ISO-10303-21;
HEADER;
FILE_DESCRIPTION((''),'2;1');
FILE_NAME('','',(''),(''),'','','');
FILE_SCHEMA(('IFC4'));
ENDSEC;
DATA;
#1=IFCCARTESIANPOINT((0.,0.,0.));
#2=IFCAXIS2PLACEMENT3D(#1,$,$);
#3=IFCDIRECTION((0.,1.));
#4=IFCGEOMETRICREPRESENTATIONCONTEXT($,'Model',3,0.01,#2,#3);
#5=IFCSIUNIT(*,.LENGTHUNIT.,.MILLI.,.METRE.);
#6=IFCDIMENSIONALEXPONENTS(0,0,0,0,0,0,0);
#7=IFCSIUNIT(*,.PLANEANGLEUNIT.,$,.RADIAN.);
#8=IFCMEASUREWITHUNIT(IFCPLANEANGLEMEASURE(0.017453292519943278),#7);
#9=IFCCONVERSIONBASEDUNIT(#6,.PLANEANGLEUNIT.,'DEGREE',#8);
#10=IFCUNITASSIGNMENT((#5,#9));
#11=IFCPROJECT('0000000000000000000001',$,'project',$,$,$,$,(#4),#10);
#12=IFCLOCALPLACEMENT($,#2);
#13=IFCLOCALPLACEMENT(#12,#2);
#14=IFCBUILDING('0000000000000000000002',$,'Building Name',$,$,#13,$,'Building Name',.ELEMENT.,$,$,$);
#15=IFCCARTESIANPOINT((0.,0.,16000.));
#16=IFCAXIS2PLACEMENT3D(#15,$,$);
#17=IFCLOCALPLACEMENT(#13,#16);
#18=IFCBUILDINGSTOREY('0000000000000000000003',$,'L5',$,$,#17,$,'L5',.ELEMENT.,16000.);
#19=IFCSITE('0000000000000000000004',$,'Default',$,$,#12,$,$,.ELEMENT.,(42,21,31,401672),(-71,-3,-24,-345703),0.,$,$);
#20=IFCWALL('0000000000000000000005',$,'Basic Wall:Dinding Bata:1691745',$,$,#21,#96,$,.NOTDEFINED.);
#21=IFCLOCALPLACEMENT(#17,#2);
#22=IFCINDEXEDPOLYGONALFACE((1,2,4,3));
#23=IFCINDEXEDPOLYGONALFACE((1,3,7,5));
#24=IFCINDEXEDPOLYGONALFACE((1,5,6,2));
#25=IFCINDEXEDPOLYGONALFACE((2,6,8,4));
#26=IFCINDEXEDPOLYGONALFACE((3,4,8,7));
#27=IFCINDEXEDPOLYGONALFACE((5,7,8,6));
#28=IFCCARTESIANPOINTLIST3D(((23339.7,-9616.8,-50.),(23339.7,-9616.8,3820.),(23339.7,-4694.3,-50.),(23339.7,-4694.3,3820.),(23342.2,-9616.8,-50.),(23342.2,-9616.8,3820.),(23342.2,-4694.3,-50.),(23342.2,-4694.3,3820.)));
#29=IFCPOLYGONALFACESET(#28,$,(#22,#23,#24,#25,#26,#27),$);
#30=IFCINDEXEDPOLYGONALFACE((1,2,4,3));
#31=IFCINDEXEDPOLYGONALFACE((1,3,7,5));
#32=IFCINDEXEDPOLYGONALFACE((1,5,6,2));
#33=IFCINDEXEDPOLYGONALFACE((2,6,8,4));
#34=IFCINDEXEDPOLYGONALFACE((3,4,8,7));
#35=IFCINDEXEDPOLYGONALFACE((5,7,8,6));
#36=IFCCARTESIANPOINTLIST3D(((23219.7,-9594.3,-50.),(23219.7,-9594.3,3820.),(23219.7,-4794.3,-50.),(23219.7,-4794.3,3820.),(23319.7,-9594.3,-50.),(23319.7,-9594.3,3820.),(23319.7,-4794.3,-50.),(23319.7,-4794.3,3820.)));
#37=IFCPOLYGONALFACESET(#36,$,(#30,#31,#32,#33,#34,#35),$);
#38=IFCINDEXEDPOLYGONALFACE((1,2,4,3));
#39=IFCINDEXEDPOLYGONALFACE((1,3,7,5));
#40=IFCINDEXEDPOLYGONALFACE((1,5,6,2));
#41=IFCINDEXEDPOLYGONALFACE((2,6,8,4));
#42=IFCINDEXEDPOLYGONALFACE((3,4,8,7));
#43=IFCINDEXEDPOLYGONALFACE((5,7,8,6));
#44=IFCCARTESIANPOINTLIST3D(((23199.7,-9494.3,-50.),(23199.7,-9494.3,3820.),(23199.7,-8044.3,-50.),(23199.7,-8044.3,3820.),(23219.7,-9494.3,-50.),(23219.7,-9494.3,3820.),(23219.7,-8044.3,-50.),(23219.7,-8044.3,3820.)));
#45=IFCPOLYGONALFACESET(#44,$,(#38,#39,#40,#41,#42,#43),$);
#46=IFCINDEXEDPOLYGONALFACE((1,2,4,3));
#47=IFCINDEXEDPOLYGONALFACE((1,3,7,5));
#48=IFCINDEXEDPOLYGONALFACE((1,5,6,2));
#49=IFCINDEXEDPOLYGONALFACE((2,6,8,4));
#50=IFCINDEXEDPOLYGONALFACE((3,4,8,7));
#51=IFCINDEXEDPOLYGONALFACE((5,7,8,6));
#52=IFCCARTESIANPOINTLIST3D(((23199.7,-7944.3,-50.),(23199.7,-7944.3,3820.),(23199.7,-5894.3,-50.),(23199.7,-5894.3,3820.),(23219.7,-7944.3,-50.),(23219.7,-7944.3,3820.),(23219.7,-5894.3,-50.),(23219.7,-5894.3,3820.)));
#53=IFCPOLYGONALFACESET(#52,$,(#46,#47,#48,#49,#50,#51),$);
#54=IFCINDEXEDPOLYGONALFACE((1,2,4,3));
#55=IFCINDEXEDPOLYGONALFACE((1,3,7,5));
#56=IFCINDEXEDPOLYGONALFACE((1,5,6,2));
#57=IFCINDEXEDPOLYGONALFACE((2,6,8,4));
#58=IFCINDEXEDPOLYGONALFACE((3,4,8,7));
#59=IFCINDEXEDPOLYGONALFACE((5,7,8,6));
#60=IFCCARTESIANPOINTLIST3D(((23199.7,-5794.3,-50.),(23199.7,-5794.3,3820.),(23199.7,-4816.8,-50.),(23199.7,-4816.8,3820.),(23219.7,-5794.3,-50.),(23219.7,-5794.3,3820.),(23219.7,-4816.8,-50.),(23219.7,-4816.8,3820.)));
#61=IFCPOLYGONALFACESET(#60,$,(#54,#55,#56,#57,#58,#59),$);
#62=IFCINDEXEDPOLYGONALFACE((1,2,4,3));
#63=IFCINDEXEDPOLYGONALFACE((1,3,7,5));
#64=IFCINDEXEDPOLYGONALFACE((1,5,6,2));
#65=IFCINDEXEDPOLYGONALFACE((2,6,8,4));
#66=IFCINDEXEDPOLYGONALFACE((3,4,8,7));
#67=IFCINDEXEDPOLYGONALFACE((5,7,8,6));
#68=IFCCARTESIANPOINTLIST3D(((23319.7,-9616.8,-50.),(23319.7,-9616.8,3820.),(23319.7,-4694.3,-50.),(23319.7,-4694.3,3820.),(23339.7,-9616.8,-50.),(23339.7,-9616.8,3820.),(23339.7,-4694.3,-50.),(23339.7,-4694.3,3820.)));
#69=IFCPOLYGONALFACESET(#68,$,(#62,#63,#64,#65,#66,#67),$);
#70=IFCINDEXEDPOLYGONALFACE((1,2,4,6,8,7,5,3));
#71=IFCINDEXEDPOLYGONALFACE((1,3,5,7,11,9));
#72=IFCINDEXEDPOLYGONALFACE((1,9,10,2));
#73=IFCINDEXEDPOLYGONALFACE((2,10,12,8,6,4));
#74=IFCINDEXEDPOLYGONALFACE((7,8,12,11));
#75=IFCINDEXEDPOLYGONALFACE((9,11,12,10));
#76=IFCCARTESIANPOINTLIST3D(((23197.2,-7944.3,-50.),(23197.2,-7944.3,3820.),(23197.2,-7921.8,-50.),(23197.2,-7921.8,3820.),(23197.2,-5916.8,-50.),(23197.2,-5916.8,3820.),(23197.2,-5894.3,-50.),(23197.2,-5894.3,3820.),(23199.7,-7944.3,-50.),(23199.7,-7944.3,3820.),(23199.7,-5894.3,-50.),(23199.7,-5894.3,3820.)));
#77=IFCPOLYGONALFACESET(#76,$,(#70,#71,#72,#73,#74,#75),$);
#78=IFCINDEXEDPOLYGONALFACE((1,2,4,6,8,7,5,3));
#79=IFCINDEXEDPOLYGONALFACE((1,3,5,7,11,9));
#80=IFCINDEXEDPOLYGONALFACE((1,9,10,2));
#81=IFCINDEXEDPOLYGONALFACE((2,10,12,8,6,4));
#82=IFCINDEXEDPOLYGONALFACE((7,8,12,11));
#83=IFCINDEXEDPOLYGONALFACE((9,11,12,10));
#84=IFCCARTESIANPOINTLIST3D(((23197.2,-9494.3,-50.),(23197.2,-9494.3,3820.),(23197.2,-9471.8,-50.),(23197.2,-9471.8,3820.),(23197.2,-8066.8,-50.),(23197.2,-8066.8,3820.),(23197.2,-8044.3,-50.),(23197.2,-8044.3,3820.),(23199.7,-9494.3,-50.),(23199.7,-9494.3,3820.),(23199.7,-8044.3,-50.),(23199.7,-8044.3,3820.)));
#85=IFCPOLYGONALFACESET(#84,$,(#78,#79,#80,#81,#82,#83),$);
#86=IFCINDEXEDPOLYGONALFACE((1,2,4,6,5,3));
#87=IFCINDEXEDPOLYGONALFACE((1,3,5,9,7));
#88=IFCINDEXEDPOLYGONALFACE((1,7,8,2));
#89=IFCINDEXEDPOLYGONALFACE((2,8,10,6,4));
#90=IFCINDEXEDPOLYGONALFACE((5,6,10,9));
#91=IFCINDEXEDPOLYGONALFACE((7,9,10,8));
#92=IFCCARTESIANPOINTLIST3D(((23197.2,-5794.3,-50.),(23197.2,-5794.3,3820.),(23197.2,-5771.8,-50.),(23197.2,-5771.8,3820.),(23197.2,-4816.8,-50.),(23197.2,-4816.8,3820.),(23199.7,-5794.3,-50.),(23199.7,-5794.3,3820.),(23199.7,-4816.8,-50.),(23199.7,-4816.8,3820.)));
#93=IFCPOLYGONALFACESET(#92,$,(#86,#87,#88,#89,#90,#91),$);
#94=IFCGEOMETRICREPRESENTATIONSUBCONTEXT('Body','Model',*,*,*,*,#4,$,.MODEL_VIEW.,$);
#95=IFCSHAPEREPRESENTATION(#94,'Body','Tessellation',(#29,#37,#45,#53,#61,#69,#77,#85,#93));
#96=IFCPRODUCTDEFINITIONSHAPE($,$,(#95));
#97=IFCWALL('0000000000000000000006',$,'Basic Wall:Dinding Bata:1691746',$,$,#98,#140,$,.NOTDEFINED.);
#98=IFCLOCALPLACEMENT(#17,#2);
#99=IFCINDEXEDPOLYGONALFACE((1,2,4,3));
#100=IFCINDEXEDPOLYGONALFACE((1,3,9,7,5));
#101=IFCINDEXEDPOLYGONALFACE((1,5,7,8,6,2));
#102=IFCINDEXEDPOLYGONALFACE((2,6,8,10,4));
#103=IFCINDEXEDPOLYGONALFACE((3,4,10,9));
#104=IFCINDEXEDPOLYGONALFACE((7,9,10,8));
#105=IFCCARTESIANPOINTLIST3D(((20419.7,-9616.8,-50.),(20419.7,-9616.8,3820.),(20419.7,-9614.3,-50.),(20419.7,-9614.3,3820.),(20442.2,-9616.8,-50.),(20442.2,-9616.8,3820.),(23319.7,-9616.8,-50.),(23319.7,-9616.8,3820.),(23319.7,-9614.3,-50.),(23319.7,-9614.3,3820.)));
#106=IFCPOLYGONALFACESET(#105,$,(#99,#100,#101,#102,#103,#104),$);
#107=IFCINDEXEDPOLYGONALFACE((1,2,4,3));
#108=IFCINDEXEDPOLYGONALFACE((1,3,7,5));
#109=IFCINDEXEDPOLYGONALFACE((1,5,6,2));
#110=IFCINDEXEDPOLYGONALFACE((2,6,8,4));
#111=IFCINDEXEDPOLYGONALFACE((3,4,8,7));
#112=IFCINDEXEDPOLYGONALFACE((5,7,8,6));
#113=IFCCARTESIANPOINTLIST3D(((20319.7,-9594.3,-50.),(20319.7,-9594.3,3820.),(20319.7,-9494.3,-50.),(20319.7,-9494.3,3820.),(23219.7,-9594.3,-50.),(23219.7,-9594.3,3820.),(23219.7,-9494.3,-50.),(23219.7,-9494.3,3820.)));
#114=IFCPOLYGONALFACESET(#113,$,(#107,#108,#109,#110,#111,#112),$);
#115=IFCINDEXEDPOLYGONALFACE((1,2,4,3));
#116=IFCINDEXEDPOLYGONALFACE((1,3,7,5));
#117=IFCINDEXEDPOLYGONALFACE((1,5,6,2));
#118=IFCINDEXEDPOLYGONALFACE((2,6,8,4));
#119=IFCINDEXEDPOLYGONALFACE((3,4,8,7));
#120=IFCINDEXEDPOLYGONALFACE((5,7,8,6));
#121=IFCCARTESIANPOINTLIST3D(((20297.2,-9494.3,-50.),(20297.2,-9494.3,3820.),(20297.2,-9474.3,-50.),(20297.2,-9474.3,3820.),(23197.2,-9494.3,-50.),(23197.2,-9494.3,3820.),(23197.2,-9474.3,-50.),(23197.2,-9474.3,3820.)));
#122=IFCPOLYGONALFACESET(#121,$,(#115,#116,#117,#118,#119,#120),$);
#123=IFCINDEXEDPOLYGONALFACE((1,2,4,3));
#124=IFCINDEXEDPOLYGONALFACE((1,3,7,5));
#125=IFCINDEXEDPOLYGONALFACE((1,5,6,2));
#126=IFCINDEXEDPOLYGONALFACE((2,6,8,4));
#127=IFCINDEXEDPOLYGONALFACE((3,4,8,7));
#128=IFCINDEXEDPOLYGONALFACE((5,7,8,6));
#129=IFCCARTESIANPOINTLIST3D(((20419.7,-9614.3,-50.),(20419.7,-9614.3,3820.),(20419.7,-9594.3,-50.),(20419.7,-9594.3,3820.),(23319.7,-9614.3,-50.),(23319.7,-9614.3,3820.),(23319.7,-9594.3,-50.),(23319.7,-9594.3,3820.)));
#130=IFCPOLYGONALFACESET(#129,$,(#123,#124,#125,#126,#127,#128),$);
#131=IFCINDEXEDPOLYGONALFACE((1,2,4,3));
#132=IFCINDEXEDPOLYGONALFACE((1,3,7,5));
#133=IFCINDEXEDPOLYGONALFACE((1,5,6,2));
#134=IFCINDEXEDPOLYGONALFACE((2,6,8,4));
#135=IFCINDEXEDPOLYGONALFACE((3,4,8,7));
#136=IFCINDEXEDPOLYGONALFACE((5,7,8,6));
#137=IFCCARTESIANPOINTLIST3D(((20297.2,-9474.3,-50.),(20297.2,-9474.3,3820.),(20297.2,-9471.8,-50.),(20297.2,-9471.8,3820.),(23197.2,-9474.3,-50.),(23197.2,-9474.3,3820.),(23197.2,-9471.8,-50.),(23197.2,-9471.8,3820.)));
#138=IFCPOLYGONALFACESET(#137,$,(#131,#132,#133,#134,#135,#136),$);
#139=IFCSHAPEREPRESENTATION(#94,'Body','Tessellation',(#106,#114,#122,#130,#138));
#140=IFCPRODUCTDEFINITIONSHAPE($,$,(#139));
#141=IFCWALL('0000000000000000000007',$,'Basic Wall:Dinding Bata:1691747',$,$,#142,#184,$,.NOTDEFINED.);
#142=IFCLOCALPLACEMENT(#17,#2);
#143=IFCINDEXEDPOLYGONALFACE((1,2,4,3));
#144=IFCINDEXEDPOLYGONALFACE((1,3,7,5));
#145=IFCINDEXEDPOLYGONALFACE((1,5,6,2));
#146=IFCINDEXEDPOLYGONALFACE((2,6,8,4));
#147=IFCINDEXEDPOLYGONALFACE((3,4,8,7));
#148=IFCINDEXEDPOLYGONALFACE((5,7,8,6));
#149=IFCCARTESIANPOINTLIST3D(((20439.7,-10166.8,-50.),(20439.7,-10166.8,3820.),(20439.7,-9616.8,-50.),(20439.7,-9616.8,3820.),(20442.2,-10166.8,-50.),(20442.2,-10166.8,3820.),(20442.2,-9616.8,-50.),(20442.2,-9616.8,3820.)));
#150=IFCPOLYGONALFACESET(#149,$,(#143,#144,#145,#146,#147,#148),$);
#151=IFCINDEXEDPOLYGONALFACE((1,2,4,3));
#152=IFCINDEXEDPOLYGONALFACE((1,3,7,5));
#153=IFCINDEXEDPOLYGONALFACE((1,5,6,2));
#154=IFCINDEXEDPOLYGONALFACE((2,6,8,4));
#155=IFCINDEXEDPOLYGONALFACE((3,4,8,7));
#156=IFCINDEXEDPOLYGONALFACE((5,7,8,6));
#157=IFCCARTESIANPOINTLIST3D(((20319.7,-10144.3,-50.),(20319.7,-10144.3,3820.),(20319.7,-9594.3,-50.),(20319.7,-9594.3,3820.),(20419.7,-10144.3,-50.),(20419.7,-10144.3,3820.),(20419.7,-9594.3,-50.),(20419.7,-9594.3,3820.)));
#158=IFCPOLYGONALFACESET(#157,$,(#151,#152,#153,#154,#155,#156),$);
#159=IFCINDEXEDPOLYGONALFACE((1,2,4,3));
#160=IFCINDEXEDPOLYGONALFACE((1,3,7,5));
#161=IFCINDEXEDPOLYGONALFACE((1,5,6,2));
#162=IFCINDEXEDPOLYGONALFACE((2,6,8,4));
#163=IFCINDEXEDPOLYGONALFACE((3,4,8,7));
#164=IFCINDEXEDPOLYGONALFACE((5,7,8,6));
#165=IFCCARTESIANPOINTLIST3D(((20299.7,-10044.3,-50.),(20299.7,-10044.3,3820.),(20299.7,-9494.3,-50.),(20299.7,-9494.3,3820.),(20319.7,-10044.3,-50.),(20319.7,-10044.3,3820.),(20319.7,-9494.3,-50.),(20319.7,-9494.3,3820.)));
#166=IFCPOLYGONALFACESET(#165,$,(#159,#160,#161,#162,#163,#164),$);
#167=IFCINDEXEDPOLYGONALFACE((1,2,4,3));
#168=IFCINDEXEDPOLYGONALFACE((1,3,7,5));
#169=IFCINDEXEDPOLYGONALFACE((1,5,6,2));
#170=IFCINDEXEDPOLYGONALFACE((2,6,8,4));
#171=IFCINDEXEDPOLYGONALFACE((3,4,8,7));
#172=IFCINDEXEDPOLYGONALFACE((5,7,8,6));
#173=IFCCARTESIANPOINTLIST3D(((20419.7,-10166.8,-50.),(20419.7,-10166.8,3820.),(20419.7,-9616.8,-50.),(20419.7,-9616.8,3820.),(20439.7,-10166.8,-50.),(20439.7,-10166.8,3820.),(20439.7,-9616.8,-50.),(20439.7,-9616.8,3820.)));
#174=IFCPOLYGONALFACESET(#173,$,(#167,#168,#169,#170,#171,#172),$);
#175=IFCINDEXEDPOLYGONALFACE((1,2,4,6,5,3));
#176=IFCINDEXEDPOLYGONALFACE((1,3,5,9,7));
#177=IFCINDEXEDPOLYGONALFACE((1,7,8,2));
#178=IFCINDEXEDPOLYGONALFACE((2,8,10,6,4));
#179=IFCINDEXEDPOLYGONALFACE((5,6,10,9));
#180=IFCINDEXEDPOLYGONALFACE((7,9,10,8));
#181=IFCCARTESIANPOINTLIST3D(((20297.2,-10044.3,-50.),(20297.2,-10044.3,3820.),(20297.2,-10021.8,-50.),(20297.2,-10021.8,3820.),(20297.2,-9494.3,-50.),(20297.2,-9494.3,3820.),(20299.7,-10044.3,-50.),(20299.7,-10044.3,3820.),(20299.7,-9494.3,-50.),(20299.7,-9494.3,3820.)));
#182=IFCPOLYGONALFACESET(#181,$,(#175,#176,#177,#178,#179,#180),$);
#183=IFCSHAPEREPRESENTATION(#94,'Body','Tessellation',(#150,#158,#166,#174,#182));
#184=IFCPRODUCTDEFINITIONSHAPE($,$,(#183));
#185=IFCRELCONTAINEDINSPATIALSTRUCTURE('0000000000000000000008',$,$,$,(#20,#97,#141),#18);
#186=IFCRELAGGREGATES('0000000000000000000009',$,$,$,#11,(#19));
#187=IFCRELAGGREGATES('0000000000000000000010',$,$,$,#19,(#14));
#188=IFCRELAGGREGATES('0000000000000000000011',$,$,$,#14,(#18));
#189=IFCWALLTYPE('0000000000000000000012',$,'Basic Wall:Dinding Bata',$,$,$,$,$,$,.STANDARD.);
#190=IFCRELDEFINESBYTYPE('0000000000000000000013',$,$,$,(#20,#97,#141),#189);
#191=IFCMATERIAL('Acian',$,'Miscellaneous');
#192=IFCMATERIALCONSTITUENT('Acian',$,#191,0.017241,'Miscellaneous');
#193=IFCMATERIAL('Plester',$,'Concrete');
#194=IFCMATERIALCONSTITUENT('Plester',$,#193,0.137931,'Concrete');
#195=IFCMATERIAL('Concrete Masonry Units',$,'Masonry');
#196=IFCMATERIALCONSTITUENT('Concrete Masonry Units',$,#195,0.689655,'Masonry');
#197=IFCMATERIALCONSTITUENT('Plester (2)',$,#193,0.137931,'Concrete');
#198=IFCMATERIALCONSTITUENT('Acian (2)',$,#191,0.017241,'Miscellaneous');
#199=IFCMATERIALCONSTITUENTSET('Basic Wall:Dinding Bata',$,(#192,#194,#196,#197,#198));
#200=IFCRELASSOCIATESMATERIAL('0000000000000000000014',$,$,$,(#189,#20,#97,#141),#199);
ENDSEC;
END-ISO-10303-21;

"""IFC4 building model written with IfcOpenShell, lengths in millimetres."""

from ifc_helpers import new_model, entity, si_unit, converted_unit, direction, frame, origin, place, context, subcontext, project, spatial, indexed_curve, outline, extrude, material, constituent, constituent_set, type_object, element, save


model = new_model("IFC4")

# Units and contexts
model_context = context("Model", 3, precision=0.01, world=origin(), true_north=direction((0.0, 1.0)))
body_context = subcontext(model_context, "Body", "Model", "MODEL_VIEW")
ifc_project = project(units=[si_unit("LENGTHUNIT", "METRE", prefix="MILLI"), converted_unit("PLANEANGLEUNIT", "DEGREE", entity("IfcPlaneAngleMeasure", 0.017453292519943278), si_unit("PLANEANGLEUNIT", "RADIAN"), dimensions=[0, 0, 0, 0, 0, 0, 0])], contexts=[model_context])

# Site, building, storey
site_placement = place(None, origin())
site = spatial("IfcSite", under=ifc_project, at=site_placement, Name="Default", CompositionType="ELEMENT", RefLatitude=(42, 21, 31, 401672), RefLongitude=(-71, -3, -24, -345703), RefElevation=0.0)
building_placement = place(site_placement, origin())
building = spatial("IfcBuilding", under=site, at=building_placement, Name="Building Name", LongName="Building Name", CompositionType="ELEMENT")
storey_placement = place(building_placement, frame((0.0, 0.0, 16000.0)))
storey = spatial("IfcBuildingStorey", under=building, at=storey_placement, Name="L5", LongName="L5", CompositionType="ELEMENT", Elevation=16000.0)

# Walls
ifc_material_1 = material(Name="Acian", Category="Miscellaneous")
ifc_constituent_1 = constituent(ifc_material_1, Name="Acian", Category="Miscellaneous", fraction=0.017241)
ifc_material_2 = material(Name="Plester", Category="Concrete")
ifc_constituent_2 = constituent(ifc_material_2, Name="Plester", Category="Concrete", fraction=0.137931)
ifc_material_3 = material(Name="Concrete Masonry Units", Category="Masonry")
ifc_constituent_3 = constituent(ifc_material_3, Name="Concrete Masonry Units", Category="Masonry", fraction=0.689655)
ifc_constituent_4 = constituent(ifc_material_2, Name="Plester (2)", Category="Concrete", fraction=0.137931)
ifc_constituent_5 = constituent(ifc_material_1, Name="Acian (2)", Category="Miscellaneous", fraction=0.017241)
ifc_constituent_set = constituent_set(constituents=[ifc_constituent_1, ifc_constituent_2, ifc_constituent_3, ifc_constituent_4, ifc_constituent_5], Name="Basic Wall:Dinding Bata")
wall_type = type_object("IfcWallType", Name="Basic Wall:Dinding Bata", PredefinedType="STANDARD", material=ifc_constituent_set)
wall_1_placement = place(storey_placement, frame((23269.7, -4816.8, -50.0), z_axis=(0.0, 0.0, 1.0), x_axis=(0.0, -1.0, 0.0)))
element("IfcWall", 1, at=wall_1_placement, inside=storey, type_object=wall_type, material=ifc_constituent_set, Name="Basic Wall:Dinding Bata:1691745", PredefinedType="NOTDEFINED", context=body_context, shape_type="SweptSolid", body=[
    extrude(outline(indexed_curve([(-1.3, -2461.3), (1.2, -2461.3), (1.3, 2461.3), (-1.2, 2461.3), (-1.3, -2461.3)], self_intersect=False)), frame((2338.8, 71.3, 0.0), z_axis=(0.0, 0.0, 1.0), x_axis=(0.0, -1.0, 0.0)), (0.0, 0.0, 1.0), 3870.0),
    extrude(outline(indexed_curve([(-2400.0, -50.0), (2400.0, -50.0), (2400.0, 50.0), (-2400.0, 50.0), (-2400.0, -50.0)], self_intersect=False)), frame((2377.5, 0.0, 0.0)), (0.0, 0.0, 1.0), 3870.0),
    extrude(outline(indexed_curve([(-725.0, -10.0), (725.0, -10.0), (725.0, 10.0), (-725.0, 10.0), (-725.0, -10.0)], self_intersect=False)), frame((3952.5, -60.0, 0.0), z_axis=(0.0, 0.0, 1.0), x_axis=(-1.0, 0.0, 0.0)), (0.0, 0.0, 1.0), 3870.0),
    extrude(outline(indexed_curve([(-1025.0, -10.0), (1025.0, -10.0), (1025.0, 10.0), (-1025.0, 10.0), (-1025.0, -10.0)], self_intersect=False)), frame((2102.5, -60.0, 0.0)), (0.0, 0.0, 1.0), 3870.0),
    extrude(outline(indexed_curve([(-488.7, -10.0), (488.7, -10.0), (488.7, 10.0), (-488.7, 10.0), (-488.7, -10.0)], self_intersect=False)), frame((488.7, -60.0, 0.0)), (0.0, 0.0, 1.0), 3870.0),
    extrude(outline(indexed_curve([(-2461.3, -10.0), (2461.3, -10.0), (2461.3, 10.0), (-2461.3, 10.0), (-2461.3, -10.0)], self_intersect=False)), frame((2338.8, 60.0, 0.0)), (0.0, 0.0, 1.0), 3870.0),
    extrude(outline(indexed_curve([(1002.5, -0.8), (1025.0, -0.8), (1025.0, 1.7), (-1025.0, 1.7), (-1025.0, -0.8), (-1002.5, -0.8), (1002.5, -0.8)], self_intersect=False)), frame((2102.5, -71.7, 0.0)), (0.0, 0.0, 1.0), 3870.0),
    extrude(outline(indexed_curve([(702.5, -0.8), (725.0, -0.8), (725.0, 1.7), (-725.0, 1.7), (-725.0, -0.8), (-702.5, -0.8), (702.5, -0.8)], self_intersect=False)), frame((3952.5, -71.7, 0.0)), (0.0, 0.0, 1.0), 3870.0),
    extrude(outline(indexed_curve([(373.0, -1.0), (395.5, -1.0), (395.5, 1.5), (-582.0, 1.5), (-582.0, -1.0), (373.0, -1.0)], self_intersect=False)), frame((582.0, -71.5, 0.0)), (0.0, 0.0, 1.0), 3870.0),
])
wall_2_placement = place(storey_placement, frame((23197.2, -9544.3, -50.0), z_axis=(0.0, 0.0, 1.0), x_axis=(-1.0, 0.0, 0.0)))
element("IfcWall", 2, at=wall_2_placement, inside=storey, type_object=wall_type, material=ifc_constituent_set, Name="Basic Wall:Dinding Bata:1691746", PredefinedType="NOTDEFINED", context=body_context, shape_type="SweptSolid", body=[
    extrude(outline(indexed_curve([(-1142.0, -1.0), (1735.5, -1.0), (1735.5, 1.5), (-1164.5, 1.5), (-1164.5, -1.0), (-1142.0, -1.0)], self_intersect=False)), frame((1613.0, 71.5, 0.0), z_axis=(0.0, 0.0, 1.0), x_axis=(-1.0, 0.0, 0.0)), (0.0, 0.0, 1.0), 3870.0),
    extrude(outline(indexed_curve([(-1450.0, -50.0), (1450.0, -50.0), (1450.0, 50.0), (-1450.0, 50.0), (-1450.0, -50.0)], self_intersect=False)), frame((1427.5, 0.0, 0.0)), (0.0, 0.0, 1.0), 3870.0),
    extrude(outline(indexed_curve([(-1450.0, -10.0), (1450.0, -10.0), (1450.0, 10.0), (-1450.0, 10.0), (-1450.0, -10.0)], self_intersect=False)), frame((1450.0, -60.0, 0.0)), (0.0, 0.0, 1.0), 3870.0),
    extrude(outline(indexed_curve([(-1450.0, -10.0), (1450.0, -10.0), (1450.0, 10.0), (-1450.0, 10.0), (-1450.0, -10.0)], self_intersect=False)), frame((1327.5, 60.0, 0.0)), (0.0, 0.0, 1.0), 3870.0),
    extrude(outline(indexed_curve([(-1.3, -1450.0), (1.2, -1450.0), (1.3, 1450.0), (-1.2, 1450.0), (-1.3, -1450.0)], self_intersect=False)), frame((1450.0, -71.3, 0.0), z_axis=(0.0, 0.0, 1.0), x_axis=(0.0, 1.0, 0.0)), (0.0, 0.0, 1.0), 3870.0),
])
wall_3_placement = place(storey_placement, frame((20369.7, -9616.8, -50.0), z_axis=(0.0, 0.0, 1.0), x_axis=(0.0, -1.0, 0.0)))
element("IfcWall", 3, at=wall_3_placement, inside=storey, type_object=wall_type, material=ifc_constituent_set, Name="Basic Wall:Dinding Bata:1691747", PredefinedType="NOTDEFINED", context=body_context, shape_type="SweptSolid", body=[
    extrude(outline(indexed_curve([(-1.2, -275.0), (1.2, -275.0), (1.2, 275.0), (-1.2, 275.0), (-1.2, -275.0)], self_intersect=False)), frame((275.0, 71.3, 0.0), z_axis=(0.0, 0.0, 1.0), x_axis=(0.0, -1.0, 0.0)), (0.0, 0.0, 1.0), 3870.0),
    extrude(outline(indexed_curve([(-275.0, -50.0), (275.0, -50.0), (275.0, 50.0), (-275.0, 50.0), (-275.0, -50.0)], self_intersect=False)), frame((252.5, 0.0, 0.0)), (0.0, 0.0, 1.0), 3870.0),
    extrude(outline(indexed_curve([(-275.0, -10.0), (275.0, -10.0), (275.0, 10.0), (-275.0, 10.0), (-275.0, -10.0)], self_intersect=False)), frame((152.5, -60.0, 0.0)), (0.0, 0.0, 1.0), 3870.0),
    extrude(outline(indexed_curve([(-275.0, -10.0), (275.0, -10.0), (275.0, 10.0), (-275.0, 10.0), (-275.0, -10.0)], self_intersect=False)), frame((275.0, 60.0, 0.0)), (0.0, 0.0, 1.0), 3870.0),
    extrude(outline(indexed_curve([(202.0, -1.0), (224.5, -1.0), (224.5, 1.5), (-325.5, 1.5), (-325.5, -1.0), (202.0, -1.0)], self_intersect=False)), frame((203.0, -71.5, 0.0)), (0.0, 0.0, 1.0), 3870.0),
])

save(model, "model.ifc")
